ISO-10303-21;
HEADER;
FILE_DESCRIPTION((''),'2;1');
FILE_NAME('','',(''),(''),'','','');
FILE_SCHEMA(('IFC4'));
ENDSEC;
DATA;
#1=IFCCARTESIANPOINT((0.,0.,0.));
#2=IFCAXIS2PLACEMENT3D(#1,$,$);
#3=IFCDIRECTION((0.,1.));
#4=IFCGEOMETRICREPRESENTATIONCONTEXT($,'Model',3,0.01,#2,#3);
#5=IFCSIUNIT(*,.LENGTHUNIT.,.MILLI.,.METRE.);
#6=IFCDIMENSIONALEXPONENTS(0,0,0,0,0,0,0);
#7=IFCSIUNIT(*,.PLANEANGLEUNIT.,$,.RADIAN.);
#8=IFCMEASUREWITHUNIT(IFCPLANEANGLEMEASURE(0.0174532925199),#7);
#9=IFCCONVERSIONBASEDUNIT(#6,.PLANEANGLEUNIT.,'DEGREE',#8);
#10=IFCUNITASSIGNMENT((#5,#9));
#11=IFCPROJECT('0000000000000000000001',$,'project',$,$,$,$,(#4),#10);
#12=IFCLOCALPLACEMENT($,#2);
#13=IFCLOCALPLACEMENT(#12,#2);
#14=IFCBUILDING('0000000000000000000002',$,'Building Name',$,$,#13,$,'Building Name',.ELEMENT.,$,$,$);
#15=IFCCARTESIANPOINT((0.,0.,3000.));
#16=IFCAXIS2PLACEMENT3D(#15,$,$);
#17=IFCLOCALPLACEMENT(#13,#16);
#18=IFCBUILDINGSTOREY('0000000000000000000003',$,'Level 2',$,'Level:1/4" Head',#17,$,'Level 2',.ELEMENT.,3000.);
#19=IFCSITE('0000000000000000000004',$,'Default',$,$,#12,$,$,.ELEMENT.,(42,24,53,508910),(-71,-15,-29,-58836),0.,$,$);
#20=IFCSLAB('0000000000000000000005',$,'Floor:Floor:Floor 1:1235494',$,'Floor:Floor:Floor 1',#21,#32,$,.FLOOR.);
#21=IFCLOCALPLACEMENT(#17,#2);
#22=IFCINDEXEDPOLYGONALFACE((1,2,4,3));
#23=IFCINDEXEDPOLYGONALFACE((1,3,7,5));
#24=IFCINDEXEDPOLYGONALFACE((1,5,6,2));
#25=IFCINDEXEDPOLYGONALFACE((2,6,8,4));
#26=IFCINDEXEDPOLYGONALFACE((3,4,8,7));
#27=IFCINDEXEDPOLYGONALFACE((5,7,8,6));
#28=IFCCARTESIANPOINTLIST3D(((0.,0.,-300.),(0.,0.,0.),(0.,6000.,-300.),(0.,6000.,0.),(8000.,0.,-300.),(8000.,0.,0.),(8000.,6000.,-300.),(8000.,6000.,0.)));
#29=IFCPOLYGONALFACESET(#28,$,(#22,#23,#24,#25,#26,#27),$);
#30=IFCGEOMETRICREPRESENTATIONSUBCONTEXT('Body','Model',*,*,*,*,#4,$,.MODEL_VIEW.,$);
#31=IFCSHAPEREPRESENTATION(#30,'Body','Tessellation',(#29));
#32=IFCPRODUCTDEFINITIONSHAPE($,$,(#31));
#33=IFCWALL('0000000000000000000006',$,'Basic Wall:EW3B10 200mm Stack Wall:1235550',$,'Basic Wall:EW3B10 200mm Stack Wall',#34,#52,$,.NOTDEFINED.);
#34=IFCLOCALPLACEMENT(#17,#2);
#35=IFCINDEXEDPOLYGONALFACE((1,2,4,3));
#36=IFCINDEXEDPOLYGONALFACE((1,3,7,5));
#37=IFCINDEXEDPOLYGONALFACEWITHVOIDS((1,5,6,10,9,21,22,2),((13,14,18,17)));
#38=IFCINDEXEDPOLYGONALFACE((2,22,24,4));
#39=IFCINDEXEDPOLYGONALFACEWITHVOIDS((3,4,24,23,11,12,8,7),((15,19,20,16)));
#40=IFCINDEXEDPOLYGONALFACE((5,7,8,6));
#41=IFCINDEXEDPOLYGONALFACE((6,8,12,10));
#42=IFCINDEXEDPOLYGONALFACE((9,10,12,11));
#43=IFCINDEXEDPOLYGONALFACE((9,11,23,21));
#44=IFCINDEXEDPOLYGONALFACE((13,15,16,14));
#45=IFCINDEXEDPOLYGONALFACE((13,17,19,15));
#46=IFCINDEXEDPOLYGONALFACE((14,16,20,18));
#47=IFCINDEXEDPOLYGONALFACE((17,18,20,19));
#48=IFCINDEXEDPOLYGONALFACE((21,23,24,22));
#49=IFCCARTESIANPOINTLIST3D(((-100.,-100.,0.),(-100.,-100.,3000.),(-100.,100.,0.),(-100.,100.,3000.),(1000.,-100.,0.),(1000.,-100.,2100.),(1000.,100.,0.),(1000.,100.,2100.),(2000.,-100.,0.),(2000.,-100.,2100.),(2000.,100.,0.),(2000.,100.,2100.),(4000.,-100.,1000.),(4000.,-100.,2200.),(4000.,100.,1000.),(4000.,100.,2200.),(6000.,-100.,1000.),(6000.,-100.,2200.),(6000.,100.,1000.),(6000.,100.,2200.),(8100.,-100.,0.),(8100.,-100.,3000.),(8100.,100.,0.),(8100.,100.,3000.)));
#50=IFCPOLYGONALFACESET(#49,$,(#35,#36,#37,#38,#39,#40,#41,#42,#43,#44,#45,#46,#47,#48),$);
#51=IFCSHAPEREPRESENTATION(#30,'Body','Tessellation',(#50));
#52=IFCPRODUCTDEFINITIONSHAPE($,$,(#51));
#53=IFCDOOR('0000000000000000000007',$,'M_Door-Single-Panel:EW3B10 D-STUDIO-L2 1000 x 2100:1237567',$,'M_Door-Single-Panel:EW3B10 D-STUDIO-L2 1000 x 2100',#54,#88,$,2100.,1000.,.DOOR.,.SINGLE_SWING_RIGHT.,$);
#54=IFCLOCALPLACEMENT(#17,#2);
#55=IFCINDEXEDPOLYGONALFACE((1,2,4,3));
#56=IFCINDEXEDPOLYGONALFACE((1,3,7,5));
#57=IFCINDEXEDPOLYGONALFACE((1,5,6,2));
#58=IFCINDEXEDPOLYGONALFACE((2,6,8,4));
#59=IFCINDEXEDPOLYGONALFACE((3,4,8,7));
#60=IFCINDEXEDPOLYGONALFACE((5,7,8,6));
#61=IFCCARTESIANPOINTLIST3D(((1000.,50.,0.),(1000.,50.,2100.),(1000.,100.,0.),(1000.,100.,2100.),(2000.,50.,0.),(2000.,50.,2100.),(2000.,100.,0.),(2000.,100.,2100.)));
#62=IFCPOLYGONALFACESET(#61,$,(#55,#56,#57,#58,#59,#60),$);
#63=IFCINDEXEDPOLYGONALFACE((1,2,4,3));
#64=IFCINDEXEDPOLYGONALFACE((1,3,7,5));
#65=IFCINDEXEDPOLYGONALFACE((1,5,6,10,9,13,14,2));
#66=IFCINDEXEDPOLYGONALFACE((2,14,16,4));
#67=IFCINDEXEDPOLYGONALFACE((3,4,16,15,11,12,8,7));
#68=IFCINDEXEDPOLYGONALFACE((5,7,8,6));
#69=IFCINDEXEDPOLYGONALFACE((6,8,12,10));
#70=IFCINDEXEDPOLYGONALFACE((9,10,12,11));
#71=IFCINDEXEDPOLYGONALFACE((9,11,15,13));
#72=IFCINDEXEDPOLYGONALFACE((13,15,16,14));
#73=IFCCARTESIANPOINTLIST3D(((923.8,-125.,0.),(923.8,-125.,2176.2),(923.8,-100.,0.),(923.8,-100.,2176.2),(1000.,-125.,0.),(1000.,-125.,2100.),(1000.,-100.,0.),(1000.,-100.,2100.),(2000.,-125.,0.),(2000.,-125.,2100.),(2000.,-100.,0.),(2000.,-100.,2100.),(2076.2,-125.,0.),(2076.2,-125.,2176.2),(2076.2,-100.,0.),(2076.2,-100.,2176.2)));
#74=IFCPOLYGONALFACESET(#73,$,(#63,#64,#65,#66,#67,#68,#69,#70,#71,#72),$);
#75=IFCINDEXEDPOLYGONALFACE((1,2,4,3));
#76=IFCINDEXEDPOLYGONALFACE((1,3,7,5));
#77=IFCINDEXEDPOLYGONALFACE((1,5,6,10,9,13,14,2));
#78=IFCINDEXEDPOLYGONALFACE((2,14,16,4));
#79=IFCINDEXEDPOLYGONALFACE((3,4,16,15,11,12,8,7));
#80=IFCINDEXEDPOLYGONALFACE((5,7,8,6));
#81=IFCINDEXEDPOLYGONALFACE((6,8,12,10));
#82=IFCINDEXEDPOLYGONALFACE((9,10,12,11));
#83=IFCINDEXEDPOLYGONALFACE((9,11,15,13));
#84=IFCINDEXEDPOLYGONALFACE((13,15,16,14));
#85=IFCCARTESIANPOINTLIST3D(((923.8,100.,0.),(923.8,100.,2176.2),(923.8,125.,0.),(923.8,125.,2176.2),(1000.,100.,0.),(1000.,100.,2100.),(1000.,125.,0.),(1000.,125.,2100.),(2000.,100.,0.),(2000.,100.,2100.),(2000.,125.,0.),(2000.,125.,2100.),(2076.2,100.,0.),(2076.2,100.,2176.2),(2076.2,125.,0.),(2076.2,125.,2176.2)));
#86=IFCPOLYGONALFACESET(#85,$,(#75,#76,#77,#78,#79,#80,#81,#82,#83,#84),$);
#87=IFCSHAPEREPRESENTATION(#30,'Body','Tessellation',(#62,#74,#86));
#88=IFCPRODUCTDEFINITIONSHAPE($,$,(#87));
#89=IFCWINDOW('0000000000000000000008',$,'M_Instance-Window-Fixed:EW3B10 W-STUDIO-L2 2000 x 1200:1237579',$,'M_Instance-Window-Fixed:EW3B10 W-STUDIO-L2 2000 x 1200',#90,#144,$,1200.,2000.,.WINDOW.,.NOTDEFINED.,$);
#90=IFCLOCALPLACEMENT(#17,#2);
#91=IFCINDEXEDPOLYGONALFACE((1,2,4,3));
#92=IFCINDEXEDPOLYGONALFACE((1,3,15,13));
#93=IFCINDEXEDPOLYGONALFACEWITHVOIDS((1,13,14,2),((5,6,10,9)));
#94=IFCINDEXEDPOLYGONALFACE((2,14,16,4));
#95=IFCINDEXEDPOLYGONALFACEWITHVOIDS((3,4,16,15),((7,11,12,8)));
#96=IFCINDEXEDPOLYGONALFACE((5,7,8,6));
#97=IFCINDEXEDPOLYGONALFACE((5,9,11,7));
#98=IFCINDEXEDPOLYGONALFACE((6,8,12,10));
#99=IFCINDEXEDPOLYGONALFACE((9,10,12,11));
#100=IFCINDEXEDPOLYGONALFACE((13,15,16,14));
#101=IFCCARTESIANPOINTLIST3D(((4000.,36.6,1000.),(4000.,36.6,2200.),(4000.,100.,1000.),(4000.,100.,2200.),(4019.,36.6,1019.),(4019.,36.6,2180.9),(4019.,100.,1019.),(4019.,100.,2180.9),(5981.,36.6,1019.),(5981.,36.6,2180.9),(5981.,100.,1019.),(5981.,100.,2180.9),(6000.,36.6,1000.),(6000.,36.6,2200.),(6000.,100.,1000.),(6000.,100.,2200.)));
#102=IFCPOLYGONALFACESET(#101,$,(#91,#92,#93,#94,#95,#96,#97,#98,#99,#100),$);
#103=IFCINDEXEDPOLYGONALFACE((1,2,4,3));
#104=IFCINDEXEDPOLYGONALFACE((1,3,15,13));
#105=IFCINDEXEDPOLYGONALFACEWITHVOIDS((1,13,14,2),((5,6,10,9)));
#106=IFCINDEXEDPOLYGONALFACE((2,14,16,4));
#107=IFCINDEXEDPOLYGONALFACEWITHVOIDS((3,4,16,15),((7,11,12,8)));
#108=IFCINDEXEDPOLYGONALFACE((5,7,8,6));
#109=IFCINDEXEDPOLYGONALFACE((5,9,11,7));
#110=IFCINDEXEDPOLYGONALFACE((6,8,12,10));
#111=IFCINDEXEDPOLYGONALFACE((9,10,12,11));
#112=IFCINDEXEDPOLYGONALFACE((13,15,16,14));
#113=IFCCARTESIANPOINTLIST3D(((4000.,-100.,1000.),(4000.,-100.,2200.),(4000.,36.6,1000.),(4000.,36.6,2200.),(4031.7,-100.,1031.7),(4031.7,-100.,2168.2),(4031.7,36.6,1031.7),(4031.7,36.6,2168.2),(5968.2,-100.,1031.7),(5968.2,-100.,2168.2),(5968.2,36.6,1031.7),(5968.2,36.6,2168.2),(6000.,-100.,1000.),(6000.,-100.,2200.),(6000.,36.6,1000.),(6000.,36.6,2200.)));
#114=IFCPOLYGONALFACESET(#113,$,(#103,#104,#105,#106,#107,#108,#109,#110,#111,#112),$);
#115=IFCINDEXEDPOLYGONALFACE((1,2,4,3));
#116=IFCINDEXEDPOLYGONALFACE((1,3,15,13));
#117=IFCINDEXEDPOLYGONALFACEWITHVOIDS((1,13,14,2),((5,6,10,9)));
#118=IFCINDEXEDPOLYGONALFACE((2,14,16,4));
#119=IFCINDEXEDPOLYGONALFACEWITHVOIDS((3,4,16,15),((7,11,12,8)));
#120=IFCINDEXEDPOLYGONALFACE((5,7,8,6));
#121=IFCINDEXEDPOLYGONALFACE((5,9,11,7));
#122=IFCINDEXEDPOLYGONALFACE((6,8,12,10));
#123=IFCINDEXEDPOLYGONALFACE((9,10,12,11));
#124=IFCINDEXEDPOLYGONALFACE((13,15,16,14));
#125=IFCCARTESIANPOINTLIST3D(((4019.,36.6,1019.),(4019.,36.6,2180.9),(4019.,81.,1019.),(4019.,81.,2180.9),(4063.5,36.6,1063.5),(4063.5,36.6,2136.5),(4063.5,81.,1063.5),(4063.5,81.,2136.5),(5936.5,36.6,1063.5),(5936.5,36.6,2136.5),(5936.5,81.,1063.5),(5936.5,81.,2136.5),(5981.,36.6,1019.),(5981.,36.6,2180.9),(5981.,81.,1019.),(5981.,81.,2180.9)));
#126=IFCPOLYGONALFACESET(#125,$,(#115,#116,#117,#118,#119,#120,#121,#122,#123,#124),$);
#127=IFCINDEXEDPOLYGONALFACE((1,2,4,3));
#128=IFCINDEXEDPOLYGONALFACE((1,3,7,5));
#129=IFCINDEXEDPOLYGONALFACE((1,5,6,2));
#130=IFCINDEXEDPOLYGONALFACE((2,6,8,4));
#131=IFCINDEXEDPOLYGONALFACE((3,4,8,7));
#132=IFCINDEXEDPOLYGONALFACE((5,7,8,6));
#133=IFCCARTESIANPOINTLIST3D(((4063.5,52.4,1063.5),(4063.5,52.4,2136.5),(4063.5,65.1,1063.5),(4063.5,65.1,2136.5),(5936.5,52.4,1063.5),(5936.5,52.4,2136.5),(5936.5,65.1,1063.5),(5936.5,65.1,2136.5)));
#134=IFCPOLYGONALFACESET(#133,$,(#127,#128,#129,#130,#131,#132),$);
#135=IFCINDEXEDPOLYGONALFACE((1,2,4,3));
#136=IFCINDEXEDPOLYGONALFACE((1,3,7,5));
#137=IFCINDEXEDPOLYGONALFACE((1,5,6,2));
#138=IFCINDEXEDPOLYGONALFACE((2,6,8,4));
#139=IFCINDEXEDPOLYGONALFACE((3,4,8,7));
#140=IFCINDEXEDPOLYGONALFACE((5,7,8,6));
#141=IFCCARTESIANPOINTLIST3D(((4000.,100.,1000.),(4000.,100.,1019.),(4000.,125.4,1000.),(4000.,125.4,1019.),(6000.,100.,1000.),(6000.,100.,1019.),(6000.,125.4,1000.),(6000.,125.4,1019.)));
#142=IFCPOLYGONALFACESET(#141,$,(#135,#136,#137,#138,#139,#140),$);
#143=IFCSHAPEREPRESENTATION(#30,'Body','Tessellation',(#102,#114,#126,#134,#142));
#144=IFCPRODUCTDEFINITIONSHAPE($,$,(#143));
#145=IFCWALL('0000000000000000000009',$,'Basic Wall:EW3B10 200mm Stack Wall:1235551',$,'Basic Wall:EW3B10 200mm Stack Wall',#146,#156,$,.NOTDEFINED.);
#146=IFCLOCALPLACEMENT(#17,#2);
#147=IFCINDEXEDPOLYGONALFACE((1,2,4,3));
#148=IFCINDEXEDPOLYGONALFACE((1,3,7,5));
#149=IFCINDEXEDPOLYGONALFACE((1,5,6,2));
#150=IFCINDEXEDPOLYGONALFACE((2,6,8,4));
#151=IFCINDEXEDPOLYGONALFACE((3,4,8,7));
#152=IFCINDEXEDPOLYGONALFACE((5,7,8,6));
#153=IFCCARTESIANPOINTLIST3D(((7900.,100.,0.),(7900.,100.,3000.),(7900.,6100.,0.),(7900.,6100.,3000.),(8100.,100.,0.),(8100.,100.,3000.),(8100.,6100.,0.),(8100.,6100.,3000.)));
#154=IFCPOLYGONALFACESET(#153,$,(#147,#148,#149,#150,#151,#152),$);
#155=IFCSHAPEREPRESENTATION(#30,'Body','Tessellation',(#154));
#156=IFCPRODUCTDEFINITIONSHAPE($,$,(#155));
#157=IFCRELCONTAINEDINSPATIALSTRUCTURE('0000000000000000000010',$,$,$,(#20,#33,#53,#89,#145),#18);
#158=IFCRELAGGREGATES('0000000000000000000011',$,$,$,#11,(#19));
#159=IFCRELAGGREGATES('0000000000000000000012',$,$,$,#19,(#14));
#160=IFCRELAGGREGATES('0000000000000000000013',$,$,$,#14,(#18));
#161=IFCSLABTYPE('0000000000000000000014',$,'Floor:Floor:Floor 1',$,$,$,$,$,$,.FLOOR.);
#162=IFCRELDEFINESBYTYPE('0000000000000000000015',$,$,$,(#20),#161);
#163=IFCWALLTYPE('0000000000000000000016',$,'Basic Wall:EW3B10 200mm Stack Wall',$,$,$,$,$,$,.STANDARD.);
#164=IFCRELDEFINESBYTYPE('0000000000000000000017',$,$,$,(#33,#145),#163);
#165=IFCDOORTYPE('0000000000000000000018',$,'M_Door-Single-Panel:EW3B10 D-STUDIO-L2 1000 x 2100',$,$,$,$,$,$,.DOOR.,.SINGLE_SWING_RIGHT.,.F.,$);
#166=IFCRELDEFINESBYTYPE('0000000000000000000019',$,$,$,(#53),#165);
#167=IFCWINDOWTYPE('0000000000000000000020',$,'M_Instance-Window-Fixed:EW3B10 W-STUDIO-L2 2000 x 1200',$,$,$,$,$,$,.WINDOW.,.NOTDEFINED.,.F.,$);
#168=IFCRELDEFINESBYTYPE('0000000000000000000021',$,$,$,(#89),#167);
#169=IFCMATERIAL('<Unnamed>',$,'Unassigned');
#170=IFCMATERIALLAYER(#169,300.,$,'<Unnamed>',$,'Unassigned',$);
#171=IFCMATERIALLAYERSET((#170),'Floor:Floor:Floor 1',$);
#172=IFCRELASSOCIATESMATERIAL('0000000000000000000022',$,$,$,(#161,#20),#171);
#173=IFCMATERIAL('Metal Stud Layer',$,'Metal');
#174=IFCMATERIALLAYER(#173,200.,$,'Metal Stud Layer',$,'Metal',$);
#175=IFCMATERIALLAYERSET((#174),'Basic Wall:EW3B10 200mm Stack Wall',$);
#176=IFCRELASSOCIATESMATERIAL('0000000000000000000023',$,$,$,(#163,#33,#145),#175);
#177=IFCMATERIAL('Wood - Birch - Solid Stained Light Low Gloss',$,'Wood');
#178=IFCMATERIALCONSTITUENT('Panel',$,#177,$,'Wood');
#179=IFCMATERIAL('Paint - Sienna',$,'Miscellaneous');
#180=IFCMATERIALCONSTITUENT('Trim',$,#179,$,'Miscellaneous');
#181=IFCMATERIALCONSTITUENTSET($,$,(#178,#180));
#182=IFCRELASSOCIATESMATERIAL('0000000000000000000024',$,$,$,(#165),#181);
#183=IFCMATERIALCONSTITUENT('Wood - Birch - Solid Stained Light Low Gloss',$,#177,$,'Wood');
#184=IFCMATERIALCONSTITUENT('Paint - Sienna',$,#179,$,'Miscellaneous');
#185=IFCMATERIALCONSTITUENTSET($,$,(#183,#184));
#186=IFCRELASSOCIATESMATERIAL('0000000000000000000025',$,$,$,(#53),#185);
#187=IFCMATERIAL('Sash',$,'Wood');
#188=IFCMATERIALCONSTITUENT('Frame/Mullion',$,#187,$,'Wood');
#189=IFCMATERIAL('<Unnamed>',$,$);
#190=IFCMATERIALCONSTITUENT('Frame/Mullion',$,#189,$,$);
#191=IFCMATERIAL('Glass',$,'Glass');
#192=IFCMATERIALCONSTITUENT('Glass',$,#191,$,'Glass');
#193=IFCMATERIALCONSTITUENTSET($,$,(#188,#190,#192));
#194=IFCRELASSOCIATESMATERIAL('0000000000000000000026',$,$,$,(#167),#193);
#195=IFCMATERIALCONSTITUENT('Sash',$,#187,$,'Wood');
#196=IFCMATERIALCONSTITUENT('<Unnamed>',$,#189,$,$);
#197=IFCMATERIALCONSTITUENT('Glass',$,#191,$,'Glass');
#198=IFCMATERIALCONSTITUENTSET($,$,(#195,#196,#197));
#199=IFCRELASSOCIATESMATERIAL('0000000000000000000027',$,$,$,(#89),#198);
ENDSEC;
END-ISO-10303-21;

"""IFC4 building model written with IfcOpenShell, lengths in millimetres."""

from ifc_helpers import new_model, entity, si_unit, converted_unit, direction, frame, frame_2d, origin, origin_2d_with_axis, place, context, subcontext, project, spatial, polyline, rectangle, outline, extrude, source, transform, mapped, material, layer, layer_set, layer_usage, constituent, constituent_set, type_object, type_shapes, element, fill, save


model = new_model("IFC4")

# Units and contexts
model_context = context("Model", 3, precision=0.01, world=origin(), true_north=direction((0.0, 1.0)))
body_context = subcontext(model_context, "Body", "Model", "MODEL_VIEW")
ifc_project = project(units=[si_unit("LENGTHUNIT", "METRE", prefix="MILLI"), converted_unit("PLANEANGLEUNIT", "DEGREE", entity("IfcPlaneAngleMeasure", 0.0174532925199), si_unit("PLANEANGLEUNIT", "RADIAN"), dimensions=[0, 0, 0, 0, 0, 0, 0])], contexts=[model_context])

# Site, building, storey
site_placement = place(None, origin())
site = spatial("IfcSite", under=ifc_project, at=site_placement, Name="Default", CompositionType="ELEMENT", RefLatitude=(42, 24, 53, 508910), RefLongitude=(-71, -15, -29, -58836), RefElevation=0.0)
building_placement = place(site_placement, origin())
building = spatial("IfcBuilding", under=site, at=building_placement, Name="Building Name", LongName="Building Name", CompositionType="ELEMENT")
storey_placement = place(building_placement, frame((0.0, 0.0, 3000.0)))
storey = spatial("IfcBuildingStorey", under=building, at=storey_placement, Name="Level 2", ObjectType="Level:1/4\" Head", LongName="Level 2", CompositionType="ELEMENT", Elevation=3000.0)

# Slab
ifc_material_1 = material(Name="<Unnamed>", Category="Unassigned")
ifc_layer_1 = layer(ifc_material_1, 300.0, Name="<Unnamed>", Category="Unassigned")
ifc_layer_set_1 = layer_set([ifc_layer_1], Name="Floor:Floor:Floor 1")
ifc_layer_usage_1 = layer_usage(ifc_layer_set_1, "AXIS3", "POSITIVE", 0.0)
slab_type = type_object("IfcSlabType", Name="Floor:Floor:Floor 1", PredefinedType="FLOOR", material=ifc_layer_set_1)
slab_placement = place(storey_placement, origin())
element("IfcSlab", 1, at=slab_placement, inside=storey, type_object=slab_type, material=ifc_layer_usage_1, Name="Floor:Floor:Floor 1:1235494", ObjectType="Floor:Floor:Floor 1", PredefinedType="FLOOR", context=body_context, shape_type="SweptSolid", body=[
    extrude(rectangle(XDim=6000.0, YDim=8000.0, at=origin_2d_with_axis()), frame((4000.0, 3000.0, 0.0), z_axis=(0.0, 0.0, -1.0), x_axis=(0.0, 1.0, 0.0)), (0.0, 0.0, 1.0), 300.0),
])

# Wall, openings, door, window
ifc_material_2 = material(Name="Metal Stud Layer", Category="Metal")
ifc_layer_2 = layer(ifc_material_2, 200.0, Name="Metal Stud Layer", Category="Metal")
ifc_layer_set_2 = layer_set([ifc_layer_2], Name="Basic Wall:EW3B10 200mm Stack Wall")
ifc_layer_usage_2 = layer_usage(ifc_layer_set_2, "AXIS2", "NEGATIVE", 100.0)
wall_type = type_object("IfcWallType", Name="Basic Wall:EW3B10 200mm Stack Wall", PredefinedType="STANDARD", material=ifc_layer_set_2)
wall_1_placement = place(storey_placement, frame((-100.0, 0.0, 0.0)))
wall_1 = element("IfcWall", 2, at=wall_1_placement, inside=storey, type_object=wall_type, material=ifc_layer_usage_2, Name="Basic Wall:EW3B10 200mm Stack Wall:1235550", ObjectType="Basic Wall:EW3B10 200mm Stack Wall", PredefinedType="NOTDEFINED", context=body_context, shape_type="SweptSolid", body=[
    extrude(rectangle(XDim=8200.0, YDim=200.0, at=frame_2d((4100.0, 0.0), x_axis=(1.0, 0.0))), origin(), (0.0, 0.0, 1.0), 3000.0),
])
opening_1_placement = place(wall_1_placement, frame((1100.0, -100.0, 0.0)))
opening_1 = element("IfcOpeningElement", 3, at=opening_1_placement, cuts=wall_1, PredefinedType="OPENING", context=body_context, shape_type="SweptSolid", body=[
    extrude(rectangle(XDim=1000.0, YDim=2100.0, at=frame_2d((1050.0, 500.0), x_axis=(0.0, 1.0))), frame((0.0, 0.0, 0.0), z_axis=(0.0, 1.0, 0.0), x_axis=(0.0, 0.0, 1.0)), (0.0, 0.0, 1.0), 200.0),
])
opening_2_placement = place(wall_1_placement, frame((4100.0, -100.0, 1000.0)))
opening_2 = element("IfcOpeningElement", 4, at=opening_2_placement, cuts=wall_1, PredefinedType="OPENING", context=body_context, shape_type="SweptSolid", body=[
    extrude(rectangle(XDim=1200.0, YDim=2000.0, at=frame_2d((600.0, 1000.0), x_axis=(-1.0, 0.0))), frame((0.0, 0.0, 0.0), z_axis=(0.0, 1.0, 0.0), x_axis=(0.0, 0.0, 1.0)), (0.0, 0.0, 1.0), 200.0),
])
ifc_material_3 = material(Name="Wood - Birch - Solid Stained Light Low Gloss", Category="Wood")
ifc_constituent_1 = constituent(ifc_material_3, Name="Wood - Birch - Solid Stained Light Low Gloss", Category="Wood")
ifc_material_4 = material(Name="Paint - Sienna", Category="Miscellaneous")
ifc_constituent_2 = constituent(ifc_material_4, Name="Paint - Sienna", Category="Miscellaneous")
ifc_constituent_set_1 = constituent_set(constituents=[ifc_constituent_1, ifc_constituent_2])
ifc_constituent_3 = constituent(ifc_material_3, Name="Panel", Category="Wood")
ifc_constituent_4 = constituent(ifc_material_4, Name="Trim", Category="Miscellaneous")
ifc_constituent_set_2 = constituent_set(constituents=[ifc_constituent_3, ifc_constituent_4])
door_type = type_object("IfcDoorType", Name="M_Door-Single-Panel:EW3B10 D-STUDIO-L2 1000 x 2100", OperationType="SINGLE_SWING_RIGHT", ParameterTakesPrecedence=False, PredefinedType="DOOR", material=ifc_constituent_set_2)
shared_shape_1 = source(origin(), body_context, "Body", "SweptSolid", [
    extrude(rectangle(XDim=50.0, YDim=1000.0, at=frame_2d((0.0, 0.0), x_axis=(1.0, 0.0))), frame((500.0, 175.0, 0.0), z_axis=(0.0, 0.0, 1.0), x_axis=(0.0, 1.0, 0.0)), (0.0, 0.0, 1.0), 2100.0),
    extrude(outline(polyline([(-1107.2, -576.2), (1069.0, -576.2), (1069.0, -500.0), (-1031.0, -500.0), (-1031.0, 500.0), (1069.0, 500.0), (1069.0, 576.2), (-1107.2, 576.2), (-1107.2, -576.2)])), frame((500.0, -25.0, 1069.0), z_axis=(0.0, 1.0, 0.0), x_axis=(0.0, 0.0, -1.0)), (0.0, 0.0, 1.0), 25.0),
    extrude(outline(polyline([(-576.2, -1107.2), (576.2, -1107.2), (576.2, 1069.0), (500.0, 1069.0), (500.0, -1031.0), (-500.0, -1031.0), (-500.0, 1069.0), (-576.2, 1069.0), (-576.2, -1107.2)])), frame((500.0, 200.0, 1069.0), z_axis=(0.0, 1.0, 0.0), x_axis=(1.0, 0.0, 0.0)), (0.0, 0.0, 1.0), 25.0),
])
type_shapes(door_type, [shared_shape_1])
door_placement = place(opening_1_placement, origin())
door = element("IfcDoor", 5, at=door_placement, inside=storey, type_object=door_type, material=ifc_constituent_set_1, Name="M_Door-Single-Panel:EW3B10 D-STUDIO-L2 1000 x 2100:1237567", ObjectType="M_Door-Single-Panel:EW3B10 D-STUDIO-L2 1000 x 2100", OperationType="SINGLE_SWING_RIGHT", OverallHeight=2100.0, OverallWidth=1000.0, PredefinedType="DOOR", context=body_context, shape_type="MappedRepresentation", body=[
    mapped(shared_shape_1, transform((0.0, 0.0, 0.0), scale=1.0)),
])
fill(opening_1, door)
ifc_material_5 = material(Name="Sash", Category="Wood")
ifc_constituent_5 = constituent(ifc_material_5, Name="Sash", Category="Wood")
ifc_material_6 = material(Name="<Unnamed>")
ifc_constituent_6 = constituent(ifc_material_6, Name="<Unnamed>")
ifc_material_7 = material(Name="Glass", Category="Glass")
ifc_constituent_7 = constituent(ifc_material_7, Name="Glass", Category="Glass")
ifc_constituent_set_3 = constituent_set(constituents=[ifc_constituent_5, ifc_constituent_6, ifc_constituent_7])
ifc_constituent_8 = constituent(ifc_material_5, Name="Frame/Mullion", Category="Wood")
ifc_constituent_9 = constituent(ifc_material_6, Name="Frame/Mullion")
ifc_constituent_10 = constituent(ifc_material_7, Name="Glass", Category="Glass")
ifc_constituent_set_4 = constituent_set(constituents=[ifc_constituent_8, ifc_constituent_9, ifc_constituent_10])
window_type = type_object("IfcWindowType", Name="M_Instance-Window-Fixed:EW3B10 W-STUDIO-L2 2000 x 1200", ParameterTakesPrecedence=False, PartitioningType="NOTDEFINED", PredefinedType="WINDOW", material=ifc_constituent_set_4)
shared_shape_2 = source(origin(), body_context, "Body", "SweptSolid", [
    extrude(outline(polyline([(-600.0, -1000.0), (600.0, -1000.0), (600.0, 1000.0), (-600.0, 1000.0), (-600.0, -1000.0)]), holes=[polyline([(-581.0, -981.0), (-581.0, 981.0), (581.0, 981.0), (581.0, -981.0), (-581.0, -981.0)])]), frame((1000.0, 136.6, 600.0), z_axis=(0.0, 1.0, 0.0), x_axis=(0.0, 0.0, -1.0)), (0.0, 0.0, 1.0), 63.5),
    extrude(outline(polyline([(-1000.0, -600.0), (1000.0, -600.0), (1000.0, 600.0), (-1000.0, 600.0), (-1000.0, -600.0)]), holes=[polyline([(-968.2, -568.2), (-968.2, 568.2), (968.2, 568.2), (968.2, -568.2), (-968.2, -568.2)])]), frame((1000.0, 0.0, 600.0), z_axis=(0.0, 1.0, 0.0), x_axis=(1.0, 0.0, 0.0)), (0.0, 0.0, 1.0), 136.6),
    extrude(outline(polyline([(-981.0, -581.0), (981.0, -581.0), (981.0, 581.0), (-981.0, 581.0), (-981.0, -581.0)]), holes=[polyline([(-936.5, -536.5), (-936.5, 536.5), (936.5, 536.5), (936.5, -536.5), (-936.5, -536.5)])]), frame((1000.0, 136.6, 600.0), z_axis=(0.0, 1.0, 0.0), x_axis=(1.0, 0.0, 0.0)), (0.0, 0.0, 1.0), 44.5),
    extrude(rectangle(XDim=12.7, YDim=1873.0, at=frame_2d((0.0, 0.0), x_axis=(1.0, 0.0))), frame((1000.0, 158.8, 63.5), z_axis=(0.0, 0.0, 1.0), x_axis=(0.0, 1.0, 0.0)), (0.0, 0.0, 1.0), 1073.0),
    extrude(rectangle(XDim=25.4, YDim=2000.0, at=frame_2d((0.0, 0.0), x_axis=(1.0, 0.0))), frame((1000.0, 212.7, 0.0), z_axis=(0.0, 0.0, 1.0), x_axis=(0.0, -1.0, 0.0)), (0.0, 0.0, 1.0), 19.1),
])
type_shapes(window_type, [shared_shape_2])
window_placement = place(opening_2_placement, origin())
window = element("IfcWindow", 6, at=window_placement, inside=storey, type_object=window_type, material=ifc_constituent_set_3, Name="M_Instance-Window-Fixed:EW3B10 W-STUDIO-L2 2000 x 1200:1237579", ObjectType="M_Instance-Window-Fixed:EW3B10 W-STUDIO-L2 2000 x 1200", OverallHeight=1200.0, OverallWidth=2000.0, PartitioningType="NOTDEFINED", PredefinedType="WINDOW", context=body_context, shape_type="MappedRepresentation", body=[
    mapped(shared_shape_2, transform((0.0, 0.0, 0.0), scale=1.0)),
])
fill(opening_2, window)

# Wall
ifc_layer_usage_3 = layer_usage(ifc_layer_set_2, "AXIS2", "NEGATIVE", 100.0)
wall_2_placement = place(storey_placement, frame((8000.0, 100.0, 0.0), z_axis=(0.0, 0.0, 1.0), x_axis=(0.0, 1.0, 0.0)))
element("IfcWall", 7, at=wall_2_placement, inside=storey, type_object=wall_type, material=ifc_layer_usage_3, Name="Basic Wall:EW3B10 200mm Stack Wall:1235551", ObjectType="Basic Wall:EW3B10 200mm Stack Wall", PredefinedType="NOTDEFINED", context=body_context, shape_type="SweptSolid", body=[
    extrude(rectangle(XDim=6000.0, YDim=200.0, at=frame_2d((3000.0, 0.0), x_axis=(-1.0, 0.0))), origin(), (0.0, 0.0, 1.0), 3000.0),
])

save(model, "model.ifc")
